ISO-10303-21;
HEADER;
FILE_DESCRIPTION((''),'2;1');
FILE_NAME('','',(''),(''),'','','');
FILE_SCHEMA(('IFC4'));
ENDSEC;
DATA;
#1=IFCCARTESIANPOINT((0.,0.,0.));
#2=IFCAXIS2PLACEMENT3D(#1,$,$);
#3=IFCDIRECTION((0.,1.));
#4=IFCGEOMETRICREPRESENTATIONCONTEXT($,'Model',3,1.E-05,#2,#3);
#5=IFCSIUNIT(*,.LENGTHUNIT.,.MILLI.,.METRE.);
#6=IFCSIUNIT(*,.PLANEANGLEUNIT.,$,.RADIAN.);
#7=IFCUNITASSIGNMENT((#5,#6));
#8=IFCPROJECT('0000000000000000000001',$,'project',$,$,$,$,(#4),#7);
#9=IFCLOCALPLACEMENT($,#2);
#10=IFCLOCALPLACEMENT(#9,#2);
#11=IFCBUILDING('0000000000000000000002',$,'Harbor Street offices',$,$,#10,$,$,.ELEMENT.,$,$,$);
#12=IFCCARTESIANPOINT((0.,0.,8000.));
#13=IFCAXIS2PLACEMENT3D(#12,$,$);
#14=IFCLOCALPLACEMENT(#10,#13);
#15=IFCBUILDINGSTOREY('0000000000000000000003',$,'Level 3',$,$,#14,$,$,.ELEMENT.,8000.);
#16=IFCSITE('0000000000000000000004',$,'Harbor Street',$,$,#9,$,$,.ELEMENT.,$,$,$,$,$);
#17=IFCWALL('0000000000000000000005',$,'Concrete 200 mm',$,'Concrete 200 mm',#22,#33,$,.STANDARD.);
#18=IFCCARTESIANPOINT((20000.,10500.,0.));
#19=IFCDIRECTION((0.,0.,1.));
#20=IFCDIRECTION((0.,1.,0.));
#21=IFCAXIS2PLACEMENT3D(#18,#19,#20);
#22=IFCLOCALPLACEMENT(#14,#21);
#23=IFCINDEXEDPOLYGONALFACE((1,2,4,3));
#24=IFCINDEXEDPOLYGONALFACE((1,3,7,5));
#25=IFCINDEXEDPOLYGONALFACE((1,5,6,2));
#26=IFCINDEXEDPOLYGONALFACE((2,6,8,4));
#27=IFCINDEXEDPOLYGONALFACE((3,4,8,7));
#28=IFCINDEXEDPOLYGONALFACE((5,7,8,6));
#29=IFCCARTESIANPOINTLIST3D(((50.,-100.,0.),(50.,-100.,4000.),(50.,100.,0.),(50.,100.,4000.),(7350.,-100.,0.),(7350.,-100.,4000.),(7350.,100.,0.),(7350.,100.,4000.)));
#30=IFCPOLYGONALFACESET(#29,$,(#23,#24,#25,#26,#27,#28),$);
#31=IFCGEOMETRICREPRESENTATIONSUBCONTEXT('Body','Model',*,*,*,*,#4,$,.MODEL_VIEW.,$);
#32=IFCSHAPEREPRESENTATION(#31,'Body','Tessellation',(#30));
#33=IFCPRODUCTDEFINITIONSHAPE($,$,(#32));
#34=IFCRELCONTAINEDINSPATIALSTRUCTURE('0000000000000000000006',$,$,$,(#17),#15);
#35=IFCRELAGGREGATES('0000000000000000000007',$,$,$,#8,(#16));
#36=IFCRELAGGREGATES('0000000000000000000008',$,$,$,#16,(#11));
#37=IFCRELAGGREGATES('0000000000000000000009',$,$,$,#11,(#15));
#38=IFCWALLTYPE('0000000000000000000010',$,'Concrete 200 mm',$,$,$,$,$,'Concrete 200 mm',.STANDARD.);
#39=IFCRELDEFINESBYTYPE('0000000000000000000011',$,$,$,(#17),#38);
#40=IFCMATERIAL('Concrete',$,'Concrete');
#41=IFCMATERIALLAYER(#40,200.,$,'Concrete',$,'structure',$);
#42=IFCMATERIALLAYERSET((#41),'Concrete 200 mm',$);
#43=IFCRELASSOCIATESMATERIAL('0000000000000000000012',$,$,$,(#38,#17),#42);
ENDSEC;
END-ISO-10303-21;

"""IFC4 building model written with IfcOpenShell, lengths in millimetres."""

from ifc_helpers import new_model, si_unit, direction, frame, origin, place, context, subcontext, project, spatial, polyline, outline, extrude, material, layer, layer_set, layer_usage, type_object, element, save


model = new_model("IFC4")

# Units and contexts
model_context = context("Model", 3, precision=1e-05, world=origin(), true_north=direction((0.0, 1.0)))
body_context = subcontext(model_context, "Body", "Model", "MODEL_VIEW")
ifc_project = project(units=[si_unit("LENGTHUNIT", "METRE", prefix="MILLI"), si_unit("PLANEANGLEUNIT", "RADIAN")], contexts=[model_context])

# Site, building, storey
site_placement = place(None, origin())
site = spatial("IfcSite", under=ifc_project, at=site_placement, Name="Harbor Street", CompositionType="ELEMENT")
building_placement = place(site_placement, origin())
building = spatial("IfcBuilding", under=site, at=building_placement, Name="Harbor Street offices", CompositionType="ELEMENT")
storey_placement = place(building_placement, frame((0.0, 0.0, 8000.0)))
storey = spatial("IfcBuildingStorey", under=building, at=storey_placement, Name="Level 3", CompositionType="ELEMENT", Elevation=8000.0)

# Shared definitions
ifc_material_1 = material(Name="Concrete", Category="Concrete")

# Wall
ifc_layer_1 = layer(ifc_material_1, 200.0, Name="Concrete", Category="structure")
ifc_layer_set_1 = layer_set([ifc_layer_1], Name="Concrete 200 mm")
ifc_layer_usage_1 = layer_usage(ifc_layer_set_1, "AXIS2", "NEGATIVE", 100.0)
wall_type_1 = type_object("IfcWallType", Name="Concrete 200 mm", ElementType="Concrete 200 mm", PredefinedType="STANDARD", material=ifc_layer_set_1)
wall_1_placement = place(storey_placement, frame((20000.0, 10500.0, 0.0), z_axis=(0.0, 0.0, 1.0), x_axis=(0.0, 1.0, 0.0)))
element("IfcWall", 1, at=wall_1_placement, inside=storey, type_object=wall_type_1, material=ifc_layer_usage_1, Name="Concrete 200 mm", ObjectType="Concrete 200 mm", PredefinedType="STANDARD", context=body_context, shape_type="SweptSolid", body=[
    extrude(outline(polyline([(50.0, -100.0), (7350.0, -100.0), (7350.0, 100.0), (50.0, 100.0), (50.0, -100.0)])), origin(), (0.0, 0.0, 1.0), 4000.0),
])

save(model, "model.ifc")
